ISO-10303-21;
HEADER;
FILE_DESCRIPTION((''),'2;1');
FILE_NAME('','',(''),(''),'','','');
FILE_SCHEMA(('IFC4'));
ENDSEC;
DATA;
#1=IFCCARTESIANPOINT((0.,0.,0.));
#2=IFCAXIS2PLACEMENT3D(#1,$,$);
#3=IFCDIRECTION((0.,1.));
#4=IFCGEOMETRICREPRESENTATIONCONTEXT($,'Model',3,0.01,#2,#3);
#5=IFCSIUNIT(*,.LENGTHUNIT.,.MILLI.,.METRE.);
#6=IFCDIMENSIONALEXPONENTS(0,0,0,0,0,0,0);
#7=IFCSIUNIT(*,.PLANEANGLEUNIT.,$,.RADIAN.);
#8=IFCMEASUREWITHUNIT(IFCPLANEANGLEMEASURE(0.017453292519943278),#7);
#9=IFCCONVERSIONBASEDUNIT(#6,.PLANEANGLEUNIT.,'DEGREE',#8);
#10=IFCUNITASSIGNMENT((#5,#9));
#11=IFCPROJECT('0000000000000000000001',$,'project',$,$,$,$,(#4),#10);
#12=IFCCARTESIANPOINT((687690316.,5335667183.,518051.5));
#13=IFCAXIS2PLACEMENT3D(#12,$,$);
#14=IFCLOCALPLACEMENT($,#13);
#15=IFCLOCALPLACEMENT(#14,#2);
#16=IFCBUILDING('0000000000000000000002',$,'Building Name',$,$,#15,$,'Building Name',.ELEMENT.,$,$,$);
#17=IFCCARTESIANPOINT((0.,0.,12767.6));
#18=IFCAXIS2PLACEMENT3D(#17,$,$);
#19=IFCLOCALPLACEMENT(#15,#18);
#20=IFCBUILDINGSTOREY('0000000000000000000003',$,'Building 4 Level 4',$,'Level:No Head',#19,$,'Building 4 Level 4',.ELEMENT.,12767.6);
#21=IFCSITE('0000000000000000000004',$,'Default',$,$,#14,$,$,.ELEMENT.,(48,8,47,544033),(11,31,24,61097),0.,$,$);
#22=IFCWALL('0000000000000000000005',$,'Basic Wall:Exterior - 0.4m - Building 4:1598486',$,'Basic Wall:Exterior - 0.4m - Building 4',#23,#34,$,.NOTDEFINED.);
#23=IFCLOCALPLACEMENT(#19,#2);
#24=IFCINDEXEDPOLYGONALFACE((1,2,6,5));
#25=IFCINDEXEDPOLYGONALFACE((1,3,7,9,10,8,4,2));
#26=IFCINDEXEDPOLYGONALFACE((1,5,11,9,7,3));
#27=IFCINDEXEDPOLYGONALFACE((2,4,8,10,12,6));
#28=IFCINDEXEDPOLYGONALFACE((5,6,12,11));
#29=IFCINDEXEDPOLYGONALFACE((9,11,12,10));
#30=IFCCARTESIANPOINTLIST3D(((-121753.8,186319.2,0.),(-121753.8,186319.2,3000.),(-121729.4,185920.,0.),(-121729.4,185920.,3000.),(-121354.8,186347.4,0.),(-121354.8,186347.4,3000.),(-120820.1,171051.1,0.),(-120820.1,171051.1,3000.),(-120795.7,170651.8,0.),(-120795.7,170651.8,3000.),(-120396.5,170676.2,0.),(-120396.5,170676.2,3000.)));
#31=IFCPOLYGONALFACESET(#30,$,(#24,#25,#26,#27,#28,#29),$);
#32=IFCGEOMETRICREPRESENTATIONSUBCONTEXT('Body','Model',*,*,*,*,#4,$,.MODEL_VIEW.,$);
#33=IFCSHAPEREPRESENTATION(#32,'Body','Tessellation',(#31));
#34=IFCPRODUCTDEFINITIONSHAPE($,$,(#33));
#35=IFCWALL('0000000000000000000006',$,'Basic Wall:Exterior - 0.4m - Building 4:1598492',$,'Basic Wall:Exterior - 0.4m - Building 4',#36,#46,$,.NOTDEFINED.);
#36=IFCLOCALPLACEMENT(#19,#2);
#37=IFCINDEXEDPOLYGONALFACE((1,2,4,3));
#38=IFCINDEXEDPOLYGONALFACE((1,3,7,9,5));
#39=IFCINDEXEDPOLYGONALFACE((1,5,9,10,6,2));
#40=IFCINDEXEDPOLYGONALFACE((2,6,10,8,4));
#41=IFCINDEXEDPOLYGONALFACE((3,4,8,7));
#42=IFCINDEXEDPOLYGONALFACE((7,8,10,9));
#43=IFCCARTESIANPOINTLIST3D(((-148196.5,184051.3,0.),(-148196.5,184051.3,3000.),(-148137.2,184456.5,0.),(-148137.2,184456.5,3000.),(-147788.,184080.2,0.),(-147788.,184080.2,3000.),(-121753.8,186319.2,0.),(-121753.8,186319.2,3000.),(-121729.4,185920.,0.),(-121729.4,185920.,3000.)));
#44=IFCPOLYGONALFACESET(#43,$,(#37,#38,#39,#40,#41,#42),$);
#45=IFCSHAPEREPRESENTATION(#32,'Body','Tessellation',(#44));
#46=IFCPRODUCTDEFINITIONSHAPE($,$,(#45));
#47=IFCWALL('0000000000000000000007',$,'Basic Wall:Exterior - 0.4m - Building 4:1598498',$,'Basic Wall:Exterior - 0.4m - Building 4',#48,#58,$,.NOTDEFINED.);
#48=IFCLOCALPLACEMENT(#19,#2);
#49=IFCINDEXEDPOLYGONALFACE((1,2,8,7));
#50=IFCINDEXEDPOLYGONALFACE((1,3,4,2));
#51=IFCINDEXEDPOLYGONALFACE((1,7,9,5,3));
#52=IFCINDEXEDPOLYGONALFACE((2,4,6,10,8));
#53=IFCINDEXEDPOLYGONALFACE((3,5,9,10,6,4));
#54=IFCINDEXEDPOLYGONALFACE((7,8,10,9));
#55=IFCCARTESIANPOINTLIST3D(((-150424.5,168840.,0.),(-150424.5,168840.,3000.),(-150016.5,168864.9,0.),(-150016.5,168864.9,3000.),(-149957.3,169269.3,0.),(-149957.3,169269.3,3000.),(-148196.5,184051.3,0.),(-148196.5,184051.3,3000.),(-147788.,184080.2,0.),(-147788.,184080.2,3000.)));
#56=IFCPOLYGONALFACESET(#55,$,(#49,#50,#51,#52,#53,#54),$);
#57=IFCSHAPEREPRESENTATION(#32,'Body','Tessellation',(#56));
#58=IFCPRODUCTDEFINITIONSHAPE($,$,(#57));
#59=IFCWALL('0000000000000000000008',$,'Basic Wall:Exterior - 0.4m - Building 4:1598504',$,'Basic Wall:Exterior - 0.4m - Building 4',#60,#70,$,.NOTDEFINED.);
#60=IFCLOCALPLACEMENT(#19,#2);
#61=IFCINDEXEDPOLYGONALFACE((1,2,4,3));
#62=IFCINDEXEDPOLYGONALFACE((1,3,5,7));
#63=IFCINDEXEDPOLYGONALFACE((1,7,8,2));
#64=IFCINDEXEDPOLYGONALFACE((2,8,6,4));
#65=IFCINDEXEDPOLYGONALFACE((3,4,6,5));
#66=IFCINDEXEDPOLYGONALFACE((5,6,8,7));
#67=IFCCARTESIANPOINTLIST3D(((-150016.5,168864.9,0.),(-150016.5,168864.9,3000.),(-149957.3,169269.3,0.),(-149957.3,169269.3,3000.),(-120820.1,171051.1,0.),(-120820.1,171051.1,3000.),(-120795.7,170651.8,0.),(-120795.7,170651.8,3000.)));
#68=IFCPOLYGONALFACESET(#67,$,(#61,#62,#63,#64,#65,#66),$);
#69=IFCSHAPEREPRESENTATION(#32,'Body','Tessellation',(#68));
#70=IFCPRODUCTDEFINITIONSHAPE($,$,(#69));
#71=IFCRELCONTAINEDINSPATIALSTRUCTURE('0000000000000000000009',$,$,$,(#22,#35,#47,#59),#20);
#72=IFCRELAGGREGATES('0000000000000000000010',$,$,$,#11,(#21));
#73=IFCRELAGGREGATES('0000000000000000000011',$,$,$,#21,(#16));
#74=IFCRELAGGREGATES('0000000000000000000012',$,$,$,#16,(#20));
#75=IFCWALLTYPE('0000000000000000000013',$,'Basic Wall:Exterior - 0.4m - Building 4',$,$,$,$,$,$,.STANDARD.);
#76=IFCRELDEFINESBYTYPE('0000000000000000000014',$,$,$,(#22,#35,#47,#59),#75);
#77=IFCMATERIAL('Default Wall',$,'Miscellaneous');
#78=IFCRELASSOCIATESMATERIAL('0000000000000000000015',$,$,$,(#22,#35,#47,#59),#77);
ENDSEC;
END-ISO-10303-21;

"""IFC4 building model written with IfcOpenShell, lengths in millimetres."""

from ifc_helpers import new_model, entity, si_unit, converted_unit, direction, frame, origin, place, context, subcontext, project, spatial, indexed_curve, outline, extrude, material, type_object, element, save


model = new_model("IFC4")

# Units and contexts
model_context = context("Model", 3, precision=0.01, world=origin(), true_north=direction((0.0, 1.0)))
body_context = subcontext(model_context, "Body", "Model", "MODEL_VIEW")
ifc_project = project(units=[si_unit("LENGTHUNIT", "METRE", prefix="MILLI"), converted_unit("PLANEANGLEUNIT", "DEGREE", entity("IfcPlaneAngleMeasure", 0.017453292519943278), si_unit("PLANEANGLEUNIT", "RADIAN"), dimensions=[0, 0, 0, 0, 0, 0, 0])], contexts=[model_context])

# Site, building, storey
site_placement = place(None, frame((687690316.0, 5335667183.0, 518051.5)))
site = spatial("IfcSite", under=ifc_project, at=site_placement, Name="Default", CompositionType="ELEMENT", RefLatitude=(48, 8, 47, 544033), RefLongitude=(11, 31, 24, 61097), RefElevation=0.0)
building_placement = place(site_placement, origin())
building = spatial("IfcBuilding", under=site, at=building_placement, Name="Building Name", LongName="Building Name", CompositionType="ELEMENT")
storey_placement = place(building_placement, frame((0.0, 0.0, 12767.6)))
storey = spatial("IfcBuildingStorey", under=building, at=storey_placement, Name="Building 4 Level 4", ObjectType="Level:No Head", LongName="Building 4 Level 4", CompositionType="ELEMENT", Elevation=12767.6)

# Walls
ifc_material_1 = material(Name="Default Wall", Category="Miscellaneous")
wall_type = type_object("IfcWallType", Name="Basic Wall:Exterior - 0.4m - Building 4", PredefinedType="STANDARD")
wall_1_placement = place(storey_placement, frame((-120596.1, 170664.0, 0.0), z_axis=(0.0, 0.0, 1.0), x_axis=(-0.061037, 0.998136, 0.0)))
element("IfcWall", 1, at=wall_1_placement, inside=storey, type_object=wall_type, material=ifc_material_1, Name="Basic Wall:Exterior - 0.4m - Building 4:1598486", ObjectType="Basic Wall:Exterior - 0.4m - Building 4", PredefinedType="NOTDEFINED", context=body_context, shape_type="SweptSolid", body=[
    extrude(outline(indexed_curve([(15700.4, -200.0), (15696.7, 200.0), (15296.7, 200.0), (400.0, 200.0), (0.0, 200.0), (0.0, -200.0), (15700.4, -200.0)], self_intersect=False)), origin(), (0.0, 0.0, 1.0), 3000.0),
])
wall_2_placement = place(storey_placement, frame((-121739.7, 186119.7, 0.0), z_axis=(0.0, 0.0, 1.0), x_axis=(-0.997517, -0.070427, 0.0)))
element("IfcWall", 2, at=wall_2_placement, inside=storey, type_object=wall_type, material=ifc_material_1, Name="Basic Wall:Exterior - 0.4m - Building 4:1598492", ObjectType="Basic Wall:Exterior - 0.4m - Building 4", PredefinedType="NOTDEFINED", context=body_context, shape_type="SweptSolid", body=[
    extrude(outline(indexed_curve([(26449.1, -200.0), (26536.8, 200.0), (26127.3, 200.0), (3.8, 200.0), (0.0, -200.0), (26449.1, -200.0)], self_intersect=False)), origin(), (0.0, 0.0, 1.0), 3000.0),
])
wall_3_placement = place(storey_placement, frame((-147985.9, 184109.1, 0.0), z_axis=(0.0, 0.0, 1.0), x_axis=(-0.144921, -0.989443, 0.0)))
element("IfcWall", 3, at=wall_3_placement, inside=storey, type_object=wall_type, material=ifc_material_1, Name="Basic Wall:Exterior - 0.4m - Building 4:1598498", ObjectType="Basic Wall:Exterior - 0.4m - Building 4", PredefinedType="NOTDEFINED", context=body_context, shape_type="SweptSolid", body=[
    extrude(outline(indexed_curve([(15461.4, -200.0), (15377.6, 200.0), (14968.9, 200.0), (0.0, 200.0), (87.7, -200.0), (15461.4, -200.0)], self_intersect=False)), origin(), (0.0, 0.0, 1.0), 3000.0),
])
wall_4_placement = place(storey_placement, frame((-150028.8, 169064.6, 0.0), z_axis=(0.0, 0.0, 1.0), x_axis=(0.998136, 0.061037, 0.0)))
element("IfcWall", 4, at=wall_4_placement, inside=storey, type_object=wall_type, material=ifc_material_1, Name="Basic Wall:Exterior - 0.4m - Building 4:1598504", ObjectType="Basic Wall:Exterior - 0.4m - Building 4", PredefinedType="NOTDEFINED", context=body_context, shape_type="SweptSolid", body=[
    extrude(outline(indexed_curve([(29275.4, -200.0), (29275.4, 200.0), (83.8, 200.0), (0.0, -200.0), (29275.4, -200.0)], self_intersect=False)), origin(), (0.0, 0.0, 1.0), 3000.0),
])

save(model, "model.ifc")
